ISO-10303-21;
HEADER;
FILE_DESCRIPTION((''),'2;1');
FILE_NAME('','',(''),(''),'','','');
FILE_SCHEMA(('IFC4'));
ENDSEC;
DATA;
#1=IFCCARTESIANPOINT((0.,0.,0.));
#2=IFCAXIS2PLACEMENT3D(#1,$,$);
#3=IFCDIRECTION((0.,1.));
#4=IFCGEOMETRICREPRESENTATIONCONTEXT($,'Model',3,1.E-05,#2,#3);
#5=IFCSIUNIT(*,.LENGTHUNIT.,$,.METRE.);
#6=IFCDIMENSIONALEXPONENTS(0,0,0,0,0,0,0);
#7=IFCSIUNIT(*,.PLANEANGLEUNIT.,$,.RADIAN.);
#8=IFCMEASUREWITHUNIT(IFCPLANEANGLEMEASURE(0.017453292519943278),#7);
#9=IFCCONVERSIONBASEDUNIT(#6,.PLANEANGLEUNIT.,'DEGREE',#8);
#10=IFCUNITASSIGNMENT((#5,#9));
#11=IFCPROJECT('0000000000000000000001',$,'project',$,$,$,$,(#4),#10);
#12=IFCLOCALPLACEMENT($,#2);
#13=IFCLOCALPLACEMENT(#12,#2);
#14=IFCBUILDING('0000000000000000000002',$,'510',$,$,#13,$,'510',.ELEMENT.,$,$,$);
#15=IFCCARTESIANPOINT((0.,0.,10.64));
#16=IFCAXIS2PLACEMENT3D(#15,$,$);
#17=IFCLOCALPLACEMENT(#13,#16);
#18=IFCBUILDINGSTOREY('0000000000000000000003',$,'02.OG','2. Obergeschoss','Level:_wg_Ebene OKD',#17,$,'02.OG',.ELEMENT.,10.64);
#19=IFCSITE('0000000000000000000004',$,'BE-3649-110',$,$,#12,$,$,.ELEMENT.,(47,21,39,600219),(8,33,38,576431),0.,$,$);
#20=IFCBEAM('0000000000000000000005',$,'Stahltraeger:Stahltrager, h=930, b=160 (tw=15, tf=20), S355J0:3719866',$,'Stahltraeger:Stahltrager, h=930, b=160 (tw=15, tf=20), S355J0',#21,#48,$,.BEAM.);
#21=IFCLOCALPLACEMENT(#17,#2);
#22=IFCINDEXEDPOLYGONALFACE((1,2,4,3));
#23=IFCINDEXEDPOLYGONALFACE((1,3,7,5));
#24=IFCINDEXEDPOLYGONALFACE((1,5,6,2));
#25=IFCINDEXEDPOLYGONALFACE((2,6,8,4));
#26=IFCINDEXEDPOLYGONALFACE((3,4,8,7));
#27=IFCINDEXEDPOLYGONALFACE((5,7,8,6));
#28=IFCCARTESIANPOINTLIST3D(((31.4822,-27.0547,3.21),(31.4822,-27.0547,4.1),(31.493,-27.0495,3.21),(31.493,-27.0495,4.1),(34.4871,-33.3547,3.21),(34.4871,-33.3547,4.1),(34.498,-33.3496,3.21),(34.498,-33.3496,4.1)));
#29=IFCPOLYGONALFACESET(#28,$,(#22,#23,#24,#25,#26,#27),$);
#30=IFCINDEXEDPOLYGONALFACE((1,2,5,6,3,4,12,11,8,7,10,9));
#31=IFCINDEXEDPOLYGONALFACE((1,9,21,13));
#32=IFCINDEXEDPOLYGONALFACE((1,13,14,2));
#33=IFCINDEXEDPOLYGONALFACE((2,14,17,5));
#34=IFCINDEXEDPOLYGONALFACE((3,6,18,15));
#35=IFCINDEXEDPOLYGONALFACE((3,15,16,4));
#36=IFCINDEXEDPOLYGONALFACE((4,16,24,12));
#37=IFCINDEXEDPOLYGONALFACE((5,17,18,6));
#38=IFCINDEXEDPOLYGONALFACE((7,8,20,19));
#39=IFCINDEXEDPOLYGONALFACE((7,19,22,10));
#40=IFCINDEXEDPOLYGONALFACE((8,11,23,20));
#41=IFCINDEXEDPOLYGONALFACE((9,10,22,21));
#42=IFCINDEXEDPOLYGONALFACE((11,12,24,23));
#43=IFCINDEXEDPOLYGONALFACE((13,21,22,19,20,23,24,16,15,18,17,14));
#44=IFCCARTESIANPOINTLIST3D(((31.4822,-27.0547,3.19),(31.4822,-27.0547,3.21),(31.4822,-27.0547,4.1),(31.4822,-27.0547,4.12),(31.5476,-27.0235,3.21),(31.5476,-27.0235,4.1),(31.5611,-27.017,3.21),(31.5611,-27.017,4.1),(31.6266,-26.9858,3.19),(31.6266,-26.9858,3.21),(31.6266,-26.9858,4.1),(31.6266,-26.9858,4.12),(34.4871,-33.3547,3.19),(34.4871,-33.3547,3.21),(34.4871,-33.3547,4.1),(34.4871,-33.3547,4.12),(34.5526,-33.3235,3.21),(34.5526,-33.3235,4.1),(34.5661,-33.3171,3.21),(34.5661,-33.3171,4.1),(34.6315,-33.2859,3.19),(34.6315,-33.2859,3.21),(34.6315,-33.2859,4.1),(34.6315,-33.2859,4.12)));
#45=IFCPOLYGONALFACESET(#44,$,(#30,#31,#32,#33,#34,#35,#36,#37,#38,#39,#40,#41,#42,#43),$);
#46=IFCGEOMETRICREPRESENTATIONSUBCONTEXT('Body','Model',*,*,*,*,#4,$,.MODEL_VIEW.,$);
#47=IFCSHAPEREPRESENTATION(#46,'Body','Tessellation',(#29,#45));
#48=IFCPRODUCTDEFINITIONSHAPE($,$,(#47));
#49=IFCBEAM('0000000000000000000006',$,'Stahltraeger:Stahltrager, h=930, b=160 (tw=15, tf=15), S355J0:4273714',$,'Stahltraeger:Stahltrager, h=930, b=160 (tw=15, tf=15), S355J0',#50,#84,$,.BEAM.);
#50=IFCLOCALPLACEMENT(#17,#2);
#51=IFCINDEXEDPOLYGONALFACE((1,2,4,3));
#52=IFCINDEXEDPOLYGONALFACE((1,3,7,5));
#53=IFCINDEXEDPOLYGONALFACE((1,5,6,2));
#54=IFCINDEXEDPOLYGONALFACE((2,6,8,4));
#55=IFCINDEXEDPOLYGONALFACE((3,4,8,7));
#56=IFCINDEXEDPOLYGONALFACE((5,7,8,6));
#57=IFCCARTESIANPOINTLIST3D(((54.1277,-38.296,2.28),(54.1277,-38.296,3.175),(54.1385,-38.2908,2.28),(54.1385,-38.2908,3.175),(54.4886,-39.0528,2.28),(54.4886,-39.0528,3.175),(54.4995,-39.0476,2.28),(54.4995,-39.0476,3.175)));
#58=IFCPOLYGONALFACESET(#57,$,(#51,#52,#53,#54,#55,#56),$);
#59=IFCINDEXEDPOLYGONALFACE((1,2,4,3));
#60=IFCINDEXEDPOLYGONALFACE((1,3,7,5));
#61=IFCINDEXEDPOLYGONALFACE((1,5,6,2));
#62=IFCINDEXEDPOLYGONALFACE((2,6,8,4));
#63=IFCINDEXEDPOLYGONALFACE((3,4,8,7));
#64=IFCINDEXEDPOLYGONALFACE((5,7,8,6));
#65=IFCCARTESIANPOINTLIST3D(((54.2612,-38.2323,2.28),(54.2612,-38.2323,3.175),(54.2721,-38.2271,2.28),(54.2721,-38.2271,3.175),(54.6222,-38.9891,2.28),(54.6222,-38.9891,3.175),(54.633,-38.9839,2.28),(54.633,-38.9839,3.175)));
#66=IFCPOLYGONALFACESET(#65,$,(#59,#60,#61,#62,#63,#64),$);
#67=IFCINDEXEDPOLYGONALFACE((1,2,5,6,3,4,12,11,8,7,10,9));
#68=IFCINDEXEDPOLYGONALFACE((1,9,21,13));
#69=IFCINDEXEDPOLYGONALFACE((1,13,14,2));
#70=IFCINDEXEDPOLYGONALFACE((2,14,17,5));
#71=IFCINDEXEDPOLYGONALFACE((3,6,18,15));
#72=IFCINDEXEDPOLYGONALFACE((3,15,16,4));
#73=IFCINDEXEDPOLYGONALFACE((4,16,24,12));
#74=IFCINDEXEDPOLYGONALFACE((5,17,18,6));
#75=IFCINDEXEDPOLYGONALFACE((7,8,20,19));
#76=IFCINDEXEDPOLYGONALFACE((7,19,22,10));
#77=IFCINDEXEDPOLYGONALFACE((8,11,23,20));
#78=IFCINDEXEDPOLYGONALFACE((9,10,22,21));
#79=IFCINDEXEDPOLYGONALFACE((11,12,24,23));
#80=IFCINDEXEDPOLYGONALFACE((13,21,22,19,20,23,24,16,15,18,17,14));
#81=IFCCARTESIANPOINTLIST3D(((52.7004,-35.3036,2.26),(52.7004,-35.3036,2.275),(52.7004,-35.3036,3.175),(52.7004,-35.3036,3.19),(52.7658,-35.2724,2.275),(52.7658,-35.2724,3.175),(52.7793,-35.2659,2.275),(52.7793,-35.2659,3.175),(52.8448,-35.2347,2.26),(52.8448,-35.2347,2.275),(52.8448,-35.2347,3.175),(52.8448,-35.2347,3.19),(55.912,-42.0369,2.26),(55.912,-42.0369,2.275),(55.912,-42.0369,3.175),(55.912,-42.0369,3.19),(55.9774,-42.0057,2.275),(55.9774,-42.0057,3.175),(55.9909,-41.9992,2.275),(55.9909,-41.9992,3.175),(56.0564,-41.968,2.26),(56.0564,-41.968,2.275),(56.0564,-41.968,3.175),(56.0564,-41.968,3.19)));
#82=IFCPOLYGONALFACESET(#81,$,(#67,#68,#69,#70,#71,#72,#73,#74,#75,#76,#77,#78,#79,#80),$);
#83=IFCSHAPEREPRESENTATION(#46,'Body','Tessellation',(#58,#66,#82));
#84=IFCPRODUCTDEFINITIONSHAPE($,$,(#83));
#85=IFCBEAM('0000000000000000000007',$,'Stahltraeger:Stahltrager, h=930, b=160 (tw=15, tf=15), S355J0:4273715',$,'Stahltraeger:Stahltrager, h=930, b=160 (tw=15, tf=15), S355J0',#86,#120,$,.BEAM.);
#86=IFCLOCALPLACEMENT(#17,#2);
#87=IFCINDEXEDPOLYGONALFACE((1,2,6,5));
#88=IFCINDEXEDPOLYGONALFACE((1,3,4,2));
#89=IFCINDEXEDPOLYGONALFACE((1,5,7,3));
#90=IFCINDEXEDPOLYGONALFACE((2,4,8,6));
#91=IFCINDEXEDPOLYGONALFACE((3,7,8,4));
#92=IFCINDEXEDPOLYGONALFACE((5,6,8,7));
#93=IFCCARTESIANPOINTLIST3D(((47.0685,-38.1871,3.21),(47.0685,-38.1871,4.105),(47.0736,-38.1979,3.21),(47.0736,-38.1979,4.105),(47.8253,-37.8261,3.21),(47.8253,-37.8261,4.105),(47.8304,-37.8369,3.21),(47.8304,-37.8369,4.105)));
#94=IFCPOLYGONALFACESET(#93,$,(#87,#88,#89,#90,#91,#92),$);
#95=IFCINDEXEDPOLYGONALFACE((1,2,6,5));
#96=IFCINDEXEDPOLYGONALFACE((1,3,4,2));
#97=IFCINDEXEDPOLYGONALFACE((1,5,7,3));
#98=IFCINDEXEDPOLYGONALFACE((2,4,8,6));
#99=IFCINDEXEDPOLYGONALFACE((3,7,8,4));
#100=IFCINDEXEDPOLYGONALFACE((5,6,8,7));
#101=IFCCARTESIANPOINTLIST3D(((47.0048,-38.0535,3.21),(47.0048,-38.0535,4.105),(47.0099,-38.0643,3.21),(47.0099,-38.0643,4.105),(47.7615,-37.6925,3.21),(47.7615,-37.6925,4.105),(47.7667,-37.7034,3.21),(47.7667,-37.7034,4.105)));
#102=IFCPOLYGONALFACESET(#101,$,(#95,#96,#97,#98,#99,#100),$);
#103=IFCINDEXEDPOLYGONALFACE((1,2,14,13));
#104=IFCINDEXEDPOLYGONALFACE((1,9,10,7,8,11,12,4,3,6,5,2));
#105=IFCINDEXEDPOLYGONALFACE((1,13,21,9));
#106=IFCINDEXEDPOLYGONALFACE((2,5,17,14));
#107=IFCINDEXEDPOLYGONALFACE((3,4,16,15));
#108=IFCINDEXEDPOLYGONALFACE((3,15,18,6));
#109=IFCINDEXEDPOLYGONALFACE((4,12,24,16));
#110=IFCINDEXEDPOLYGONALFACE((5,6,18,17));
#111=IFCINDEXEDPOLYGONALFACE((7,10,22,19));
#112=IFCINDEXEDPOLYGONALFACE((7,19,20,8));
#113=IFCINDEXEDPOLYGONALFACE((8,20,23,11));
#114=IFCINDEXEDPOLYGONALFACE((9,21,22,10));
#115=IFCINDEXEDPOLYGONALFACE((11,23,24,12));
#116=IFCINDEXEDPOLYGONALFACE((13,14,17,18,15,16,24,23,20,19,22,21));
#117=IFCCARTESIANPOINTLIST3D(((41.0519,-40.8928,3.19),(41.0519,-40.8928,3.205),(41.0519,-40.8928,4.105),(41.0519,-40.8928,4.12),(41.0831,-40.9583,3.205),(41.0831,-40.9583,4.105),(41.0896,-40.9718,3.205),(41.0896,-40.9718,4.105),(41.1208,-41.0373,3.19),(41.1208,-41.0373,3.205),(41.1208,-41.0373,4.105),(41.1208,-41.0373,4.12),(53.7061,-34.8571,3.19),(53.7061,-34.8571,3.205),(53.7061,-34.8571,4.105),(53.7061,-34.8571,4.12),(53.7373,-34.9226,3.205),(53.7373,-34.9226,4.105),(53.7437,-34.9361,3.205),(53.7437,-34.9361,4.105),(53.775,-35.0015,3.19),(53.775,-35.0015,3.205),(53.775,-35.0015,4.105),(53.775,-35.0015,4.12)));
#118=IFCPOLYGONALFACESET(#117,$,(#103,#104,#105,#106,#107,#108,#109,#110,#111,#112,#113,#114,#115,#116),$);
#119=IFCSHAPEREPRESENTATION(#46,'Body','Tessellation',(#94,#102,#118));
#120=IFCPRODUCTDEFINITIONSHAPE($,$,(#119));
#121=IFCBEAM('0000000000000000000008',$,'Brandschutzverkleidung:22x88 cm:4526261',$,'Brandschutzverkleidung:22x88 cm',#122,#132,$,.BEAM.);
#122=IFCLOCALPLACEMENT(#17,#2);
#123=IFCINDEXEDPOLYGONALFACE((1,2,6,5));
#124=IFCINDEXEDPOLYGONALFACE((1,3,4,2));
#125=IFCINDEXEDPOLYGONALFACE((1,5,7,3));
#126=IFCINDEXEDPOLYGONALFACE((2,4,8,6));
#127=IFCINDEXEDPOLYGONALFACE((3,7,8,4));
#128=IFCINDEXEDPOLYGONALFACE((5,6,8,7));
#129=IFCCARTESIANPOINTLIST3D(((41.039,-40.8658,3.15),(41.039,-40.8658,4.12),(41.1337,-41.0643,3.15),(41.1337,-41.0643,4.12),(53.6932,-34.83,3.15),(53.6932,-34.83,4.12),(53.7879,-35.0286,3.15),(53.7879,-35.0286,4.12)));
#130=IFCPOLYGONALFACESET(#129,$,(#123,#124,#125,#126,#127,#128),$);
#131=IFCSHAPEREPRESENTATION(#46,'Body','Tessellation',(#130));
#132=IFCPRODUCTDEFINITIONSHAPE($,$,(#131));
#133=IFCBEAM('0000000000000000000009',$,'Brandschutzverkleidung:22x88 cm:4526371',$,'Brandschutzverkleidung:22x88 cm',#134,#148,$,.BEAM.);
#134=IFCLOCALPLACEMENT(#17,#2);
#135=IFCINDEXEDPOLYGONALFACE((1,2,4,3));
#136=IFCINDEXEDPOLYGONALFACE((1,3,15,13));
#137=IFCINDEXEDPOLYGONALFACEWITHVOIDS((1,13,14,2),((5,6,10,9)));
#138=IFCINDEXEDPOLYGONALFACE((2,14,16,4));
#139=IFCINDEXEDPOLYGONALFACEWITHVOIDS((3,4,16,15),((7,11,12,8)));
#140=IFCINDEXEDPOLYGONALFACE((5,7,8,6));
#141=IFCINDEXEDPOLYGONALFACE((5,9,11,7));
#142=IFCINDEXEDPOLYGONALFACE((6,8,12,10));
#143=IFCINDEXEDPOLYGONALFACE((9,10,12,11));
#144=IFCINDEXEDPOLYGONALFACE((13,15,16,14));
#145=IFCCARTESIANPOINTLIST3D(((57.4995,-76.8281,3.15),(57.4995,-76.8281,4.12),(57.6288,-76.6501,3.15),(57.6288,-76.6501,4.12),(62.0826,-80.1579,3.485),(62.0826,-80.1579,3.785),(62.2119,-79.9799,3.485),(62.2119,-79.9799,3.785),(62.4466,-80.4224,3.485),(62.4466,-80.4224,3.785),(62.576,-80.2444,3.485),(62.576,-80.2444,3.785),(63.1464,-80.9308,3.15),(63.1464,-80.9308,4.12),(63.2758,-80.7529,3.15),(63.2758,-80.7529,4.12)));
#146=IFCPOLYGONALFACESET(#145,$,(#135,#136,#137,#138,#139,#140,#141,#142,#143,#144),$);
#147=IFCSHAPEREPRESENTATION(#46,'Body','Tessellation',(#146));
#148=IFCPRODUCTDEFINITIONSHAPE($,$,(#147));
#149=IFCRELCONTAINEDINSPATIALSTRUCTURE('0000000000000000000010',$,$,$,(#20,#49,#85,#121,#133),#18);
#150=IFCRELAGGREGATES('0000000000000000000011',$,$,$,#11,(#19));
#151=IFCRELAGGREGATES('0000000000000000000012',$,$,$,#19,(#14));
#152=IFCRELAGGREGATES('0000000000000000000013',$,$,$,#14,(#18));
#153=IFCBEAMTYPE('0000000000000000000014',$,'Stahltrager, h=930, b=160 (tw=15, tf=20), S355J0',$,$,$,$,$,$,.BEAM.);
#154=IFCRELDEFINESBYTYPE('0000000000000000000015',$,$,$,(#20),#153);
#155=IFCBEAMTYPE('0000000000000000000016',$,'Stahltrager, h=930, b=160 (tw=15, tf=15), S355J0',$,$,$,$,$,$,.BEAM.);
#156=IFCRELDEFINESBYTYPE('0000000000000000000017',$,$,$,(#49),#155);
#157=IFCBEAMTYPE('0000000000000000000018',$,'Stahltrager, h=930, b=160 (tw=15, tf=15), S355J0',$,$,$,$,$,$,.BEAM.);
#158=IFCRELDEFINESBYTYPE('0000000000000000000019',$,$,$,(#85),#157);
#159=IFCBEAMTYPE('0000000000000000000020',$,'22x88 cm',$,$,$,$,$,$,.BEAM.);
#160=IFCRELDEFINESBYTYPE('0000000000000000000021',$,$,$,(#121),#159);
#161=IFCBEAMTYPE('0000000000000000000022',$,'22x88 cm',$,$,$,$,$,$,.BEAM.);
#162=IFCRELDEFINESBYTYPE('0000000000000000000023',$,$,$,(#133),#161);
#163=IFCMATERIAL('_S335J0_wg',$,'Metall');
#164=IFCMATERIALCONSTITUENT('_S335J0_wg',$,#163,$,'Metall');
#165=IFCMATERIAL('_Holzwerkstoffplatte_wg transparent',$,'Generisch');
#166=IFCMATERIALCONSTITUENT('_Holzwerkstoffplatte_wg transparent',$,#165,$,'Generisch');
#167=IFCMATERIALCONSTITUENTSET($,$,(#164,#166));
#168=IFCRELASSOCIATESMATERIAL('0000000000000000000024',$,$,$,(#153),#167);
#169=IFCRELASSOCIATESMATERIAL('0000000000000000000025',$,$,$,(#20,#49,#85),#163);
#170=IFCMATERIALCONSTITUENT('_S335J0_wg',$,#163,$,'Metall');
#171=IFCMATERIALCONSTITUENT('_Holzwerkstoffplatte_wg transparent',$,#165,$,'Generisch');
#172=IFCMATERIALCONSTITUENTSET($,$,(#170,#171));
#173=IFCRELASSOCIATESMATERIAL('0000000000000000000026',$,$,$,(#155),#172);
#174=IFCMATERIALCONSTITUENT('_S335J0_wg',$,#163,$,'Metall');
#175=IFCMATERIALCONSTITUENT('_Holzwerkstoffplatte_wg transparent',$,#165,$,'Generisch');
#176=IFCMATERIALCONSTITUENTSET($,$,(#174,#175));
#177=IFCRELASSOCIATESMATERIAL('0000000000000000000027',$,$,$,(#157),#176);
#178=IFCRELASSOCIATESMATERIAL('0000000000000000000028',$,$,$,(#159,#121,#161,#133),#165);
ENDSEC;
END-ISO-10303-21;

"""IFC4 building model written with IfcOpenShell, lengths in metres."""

from ifc_helpers import new_model, entity, si_unit, converted_unit, direction, frame, origin, place, context, subcontext, project, spatial, indexed_curve, outline, extrude, source, transform, mapped, material, constituent, constituent_set, type_object, type_shapes, element, save


model = new_model("IFC4")

# Units and contexts
model_context = context("Model", 3, precision=1e-05, world=origin(), true_north=direction((0.0, 1.0)))
body_context = subcontext(model_context, "Body", "Model", "MODEL_VIEW")
ifc_project = project(units=[si_unit("LENGTHUNIT", "METRE"), converted_unit("PLANEANGLEUNIT", "DEGREE", entity("IfcPlaneAngleMeasure", 0.017453292519943278), si_unit("PLANEANGLEUNIT", "RADIAN"), dimensions=[0, 0, 0, 0, 0, 0, 0])], contexts=[model_context])

# Site, building, storey
site_placement = place(None, origin())
site = spatial("IfcSite", under=ifc_project, at=site_placement, Name="BE-3649-110", CompositionType="ELEMENT", RefLatitude=(47, 21, 39, 600219), RefLongitude=(8, 33, 38, 576431), RefElevation=0.0)
building_placement = place(site_placement, origin())
building = spatial("IfcBuilding", under=site, at=building_placement, Name="510", LongName="510", CompositionType="ELEMENT")
storey_placement = place(building_placement, frame((0.0, 0.0, 10.64)))
storey = spatial("IfcBuildingStorey", under=building, at=storey_placement, Name="02.OG", Description="2. Obergeschoss", ObjectType="Level:_wg_Ebene OKD", LongName="02.OG", CompositionType="ELEMENT", Elevation=10.64)

# Beams
ifc_material_1 = material(Name="_S335J0_wg", Category="Metall")
ifc_constituent_1 = constituent(ifc_material_1, Name="_S335J0_wg", Category="Metall")
ifc_material_2 = material(Name="_Holzwerkstoffplatte_wg transparent", Category="Generisch")
ifc_constituent_2 = constituent(ifc_material_2, Name="_Holzwerkstoffplatte_wg transparent", Category="Generisch")
ifc_constituent_set_1 = constituent_set(constituents=[ifc_constituent_1, ifc_constituent_2])
beam_type_1 = type_object("IfcBeamType", Name="Stahltrager, h=930, b=160 (tw=15, tf=20), S355J0", PredefinedType="BEAM", material=ifc_constituent_set_1)
shared_shape_1 = source(origin(), body_context, "Body", "SweptSolid", [
    extrude(outline(indexed_curve([(-0.445, -0.006), (0.445, -0.006), (0.445, 0.006), (-0.445, 0.006), (-0.445, -0.006)], self_intersect=False)), frame((31.4876, -27.0521, 14.295), z_axis=(0.430511, -0.902585, 0.0), x_axis=(0.0, 0.0, -1.0)), (0.0, 0.0, 1.0), 6.98),
    extrude(outline(indexed_curve([(-0.465, -0.08), (-0.445, -0.08), (-0.445, -0.0075), (0.445, -0.0075), (0.445, -0.08), (0.465, -0.08), (0.465, 0.08), (0.445, 0.08), (0.445, 0.0075), (-0.445, 0.0075), (-0.445, 0.08), (-0.465, 0.08), (-0.465, -0.08)], self_intersect=False)), frame((31.5544, -27.0203, 14.295), z_axis=(0.430511, -0.902585, 0.0), x_axis=(0.0, 0.0, -1.0)), (0.0, 0.0, 1.0), 6.98),
])
type_shapes(beam_type_1, [shared_shape_1])
beam_1_placement = place(storey_placement, frame((0.0, 0.0, -10.64)))
element("IfcBeam", 1, at=beam_1_placement, inside=storey, type_object=beam_type_1, material=ifc_material_1, Name="Stahltraeger:Stahltrager, h=930, b=160 (tw=15, tf=20), S355J0:3719866", ObjectType="Stahltraeger:Stahltrager, h=930, b=160 (tw=15, tf=20), S355J0", PredefinedType="BEAM", context=body_context, shape_type="MappedRepresentation", body=[
    mapped(shared_shape_1, transform((0.0, 0.0, 0.0), scale=1.0)),
])
ifc_constituent_3 = constituent(ifc_material_1, Name="_S335J0_wg", Category="Metall")
ifc_constituent_4 = constituent(ifc_material_2, Name="_Holzwerkstoffplatte_wg transparent", Category="Generisch")
ifc_constituent_set_2 = constituent_set(constituents=[ifc_constituent_3, ifc_constituent_4])
beam_type_2 = type_object("IfcBeamType", Name="Stahltrager, h=930, b=160 (tw=15, tf=15), S355J0", PredefinedType="BEAM", material=ifc_constituent_set_2)
shared_shape_2 = source(origin(), body_context, "Body", "SweptSolid", [
    extrude(outline(indexed_curve([(-0.4475, -0.006), (0.4475, -0.006), (0.4475, 0.006), (-0.4475, 0.006), (-0.4475, -0.006)], self_intersect=False)), frame((54.1331, -38.2934, 13.3675), z_axis=(0.430511, -0.902585, 0.0), x_axis=(0.0, 0.0, -1.0)), (0.0, 0.0, 1.0), 0.8385),
    extrude(outline(indexed_curve([(-0.4475, -0.006), (0.4475, -0.006), (0.4475, 0.006), (-0.4475, 0.006), (-0.4475, -0.006)], self_intersect=False)), frame((54.2667, -38.2297, 13.3675), z_axis=(0.430511, -0.902585, 0.0), x_axis=(0.0, 0.0, -1.0)), (0.0, 0.0, 1.0), 0.8385),
    extrude(outline(indexed_curve([(-0.465, -0.08), (-0.45, -0.08), (-0.45, -0.0075), (0.45, -0.0075), (0.45, -0.08), (0.465, -0.08), (0.465, 0.08), (0.45, 0.08), (0.45, 0.0075), (-0.45, 0.0075), (-0.45, 0.08), (-0.465, 0.08), (-0.465, -0.08)], self_intersect=False)), frame((52.7726, -35.2691, 13.365), z_axis=(0.430511, -0.902585, 0.0), x_axis=(0.0, 0.0, -1.0)), (0.0, 0.0, 1.0), 7.46),
])
type_shapes(beam_type_2, [shared_shape_2])
beam_2_placement = place(storey_placement, frame((0.0, 0.0, -10.64)))
element("IfcBeam", 2, at=beam_2_placement, inside=storey, type_object=beam_type_2, material=ifc_material_1, Name="Stahltraeger:Stahltrager, h=930, b=160 (tw=15, tf=15), S355J0:4273714", ObjectType="Stahltraeger:Stahltrager, h=930, b=160 (tw=15, tf=15), S355J0", PredefinedType="BEAM", context=body_context, shape_type="MappedRepresentation", body=[
    mapped(shared_shape_2, transform((0.0, 0.0, 0.0), scale=1.0)),
])
ifc_constituent_5 = constituent(ifc_material_1, Name="_S335J0_wg", Category="Metall")
ifc_constituent_6 = constituent(ifc_material_2, Name="_Holzwerkstoffplatte_wg transparent", Category="Generisch")
ifc_constituent_set_3 = constituent_set(constituents=[ifc_constituent_5, ifc_constituent_6])
beam_type_3 = type_object("IfcBeamType", Name="Stahltrager, h=930, b=160 (tw=15, tf=15), S355J0", PredefinedType="BEAM", material=ifc_constituent_set_3)
shared_shape_3 = source(origin(), body_context, "Body", "SweptSolid", [
    extrude(outline(indexed_curve([(-0.4475, -0.006), (0.4475, -0.006), (0.4475, 0.006), (-0.4475, 0.006), (-0.4475, -0.006)], self_intersect=False)), frame((47.0711, -38.1925, 14.2975), z_axis=(0.902585, 0.430511, 0.0), x_axis=(0.0, 0.0, 1.0)), (0.0, 0.0, 1.0), 0.8385),
    extrude(outline(indexed_curve([(-0.4475, -0.006), (0.4475, -0.006), (0.4475, 0.006), (-0.4475, 0.006), (-0.4475, -0.006)], self_intersect=False)), frame((47.0073, -38.0589, 14.2975), z_axis=(0.902585, 0.430511, 0.0), x_axis=(0.0, 0.0, 1.0)), (0.0, 0.0, 1.0), 0.8385),
    extrude(outline(indexed_curve([(0.45, -0.08), (0.465, -0.08), (0.465, 0.08), (0.45, 0.08), (0.45, 0.0075), (-0.45, 0.0075), (-0.45, 0.08), (-0.465, 0.08), (-0.465, -0.08), (-0.45, -0.08), (-0.45, -0.0075), (0.45, -0.0075), (0.45, -0.08)], self_intersect=False)), frame((41.0864, -40.9651, 14.295), z_axis=(0.902585, 0.430511, 0.0), x_axis=(0.0, 0.0, 1.0)), (0.0, 0.0, 1.0), 14.0199),
])
type_shapes(beam_type_3, [shared_shape_3])
beam_3_placement = place(storey_placement, frame((0.0, 0.0, -10.64)))
element("IfcBeam", 3, at=beam_3_placement, inside=storey, type_object=beam_type_3, material=ifc_material_1, Name="Stahltraeger:Stahltrager, h=930, b=160 (tw=15, tf=15), S355J0:4273715", ObjectType="Stahltraeger:Stahltrager, h=930, b=160 (tw=15, tf=15), S355J0", PredefinedType="BEAM", context=body_context, shape_type="MappedRepresentation", body=[
    mapped(shared_shape_3, transform((0.0, 0.0, 0.0), scale=1.0)),
])

# Beams
beam_type_4 = type_object("IfcBeamType", Name="22x88 cm", PredefinedType="BEAM", material=ifc_material_2)
shared_shape_4 = source(origin(), body_context, "Body", "SweptSolid", [
    extrude(outline(indexed_curve([(-7.0099, -0.11), (7.0099, -0.11), (7.0099, 0.11), (-7.0099, 0.11), (-7.0099, -0.11)], self_intersect=False)), frame((47.4134, -37.9472, -0.485), z_axis=(0.0, 0.0, 1.0), x_axis=(0.902585, 0.430511, 0.0)), (0.0, 0.0, 1.0), 0.97),
])
type_shapes(beam_type_4, [shared_shape_4])
beam_4_placement = place(storey_placement, frame((0.0, 0.0, 3.635)))
element("IfcBeam", 4, at=beam_4_placement, inside=storey, type_object=beam_type_4, material=ifc_material_2, Name="Brandschutzverkleidung:22x88 cm:4526261", ObjectType="Brandschutzverkleidung:22x88 cm", PredefinedType="BEAM", context=body_context, shape_type="MappedRepresentation", body=[
    mapped(shared_shape_4, transform((0.0, 0.0, 0.0), scale=1.0)),
])
beam_type_5 = type_object("IfcBeamType", Name="22x88 cm", PredefinedType="BEAM", material=ifc_material_2)
shared_shape_5 = source(origin(), body_context, "Body", "SweptSolid", [
    extrude(outline(indexed_curve([(-3.49, -0.485), (3.49, -0.485), (3.49, 0.485), (-3.49, 0.485), (-3.49, -0.485)], self_intersect=False), holes=[indexed_curve([(2.175, -0.15), (2.175, 0.15), (2.625, 0.15), (2.625, -0.15), (2.175, -0.15)], self_intersect=False)]), frame((60.323, -78.8795, 0.0), z_axis=(0.587785, 0.809017, 0.0), x_axis=(0.809017, -0.587785, 0.0)), (0.0, 0.0, 1.0), 0.22),
])
type_shapes(beam_type_5, [shared_shape_5])
beam_5_placement = place(storey_placement, frame((0.0, 0.0, 3.635)))
element("IfcBeam", 5, at=beam_5_placement, inside=storey, type_object=beam_type_5, material=ifc_material_2, Name="Brandschutzverkleidung:22x88 cm:4526371", ObjectType="Brandschutzverkleidung:22x88 cm", PredefinedType="BEAM", context=body_context, shape_type="MappedRepresentation", body=[
    mapped(shared_shape_5, transform((0.0, 0.0, 0.0), scale=1.0)),
])

save(model, "model.ifc")
